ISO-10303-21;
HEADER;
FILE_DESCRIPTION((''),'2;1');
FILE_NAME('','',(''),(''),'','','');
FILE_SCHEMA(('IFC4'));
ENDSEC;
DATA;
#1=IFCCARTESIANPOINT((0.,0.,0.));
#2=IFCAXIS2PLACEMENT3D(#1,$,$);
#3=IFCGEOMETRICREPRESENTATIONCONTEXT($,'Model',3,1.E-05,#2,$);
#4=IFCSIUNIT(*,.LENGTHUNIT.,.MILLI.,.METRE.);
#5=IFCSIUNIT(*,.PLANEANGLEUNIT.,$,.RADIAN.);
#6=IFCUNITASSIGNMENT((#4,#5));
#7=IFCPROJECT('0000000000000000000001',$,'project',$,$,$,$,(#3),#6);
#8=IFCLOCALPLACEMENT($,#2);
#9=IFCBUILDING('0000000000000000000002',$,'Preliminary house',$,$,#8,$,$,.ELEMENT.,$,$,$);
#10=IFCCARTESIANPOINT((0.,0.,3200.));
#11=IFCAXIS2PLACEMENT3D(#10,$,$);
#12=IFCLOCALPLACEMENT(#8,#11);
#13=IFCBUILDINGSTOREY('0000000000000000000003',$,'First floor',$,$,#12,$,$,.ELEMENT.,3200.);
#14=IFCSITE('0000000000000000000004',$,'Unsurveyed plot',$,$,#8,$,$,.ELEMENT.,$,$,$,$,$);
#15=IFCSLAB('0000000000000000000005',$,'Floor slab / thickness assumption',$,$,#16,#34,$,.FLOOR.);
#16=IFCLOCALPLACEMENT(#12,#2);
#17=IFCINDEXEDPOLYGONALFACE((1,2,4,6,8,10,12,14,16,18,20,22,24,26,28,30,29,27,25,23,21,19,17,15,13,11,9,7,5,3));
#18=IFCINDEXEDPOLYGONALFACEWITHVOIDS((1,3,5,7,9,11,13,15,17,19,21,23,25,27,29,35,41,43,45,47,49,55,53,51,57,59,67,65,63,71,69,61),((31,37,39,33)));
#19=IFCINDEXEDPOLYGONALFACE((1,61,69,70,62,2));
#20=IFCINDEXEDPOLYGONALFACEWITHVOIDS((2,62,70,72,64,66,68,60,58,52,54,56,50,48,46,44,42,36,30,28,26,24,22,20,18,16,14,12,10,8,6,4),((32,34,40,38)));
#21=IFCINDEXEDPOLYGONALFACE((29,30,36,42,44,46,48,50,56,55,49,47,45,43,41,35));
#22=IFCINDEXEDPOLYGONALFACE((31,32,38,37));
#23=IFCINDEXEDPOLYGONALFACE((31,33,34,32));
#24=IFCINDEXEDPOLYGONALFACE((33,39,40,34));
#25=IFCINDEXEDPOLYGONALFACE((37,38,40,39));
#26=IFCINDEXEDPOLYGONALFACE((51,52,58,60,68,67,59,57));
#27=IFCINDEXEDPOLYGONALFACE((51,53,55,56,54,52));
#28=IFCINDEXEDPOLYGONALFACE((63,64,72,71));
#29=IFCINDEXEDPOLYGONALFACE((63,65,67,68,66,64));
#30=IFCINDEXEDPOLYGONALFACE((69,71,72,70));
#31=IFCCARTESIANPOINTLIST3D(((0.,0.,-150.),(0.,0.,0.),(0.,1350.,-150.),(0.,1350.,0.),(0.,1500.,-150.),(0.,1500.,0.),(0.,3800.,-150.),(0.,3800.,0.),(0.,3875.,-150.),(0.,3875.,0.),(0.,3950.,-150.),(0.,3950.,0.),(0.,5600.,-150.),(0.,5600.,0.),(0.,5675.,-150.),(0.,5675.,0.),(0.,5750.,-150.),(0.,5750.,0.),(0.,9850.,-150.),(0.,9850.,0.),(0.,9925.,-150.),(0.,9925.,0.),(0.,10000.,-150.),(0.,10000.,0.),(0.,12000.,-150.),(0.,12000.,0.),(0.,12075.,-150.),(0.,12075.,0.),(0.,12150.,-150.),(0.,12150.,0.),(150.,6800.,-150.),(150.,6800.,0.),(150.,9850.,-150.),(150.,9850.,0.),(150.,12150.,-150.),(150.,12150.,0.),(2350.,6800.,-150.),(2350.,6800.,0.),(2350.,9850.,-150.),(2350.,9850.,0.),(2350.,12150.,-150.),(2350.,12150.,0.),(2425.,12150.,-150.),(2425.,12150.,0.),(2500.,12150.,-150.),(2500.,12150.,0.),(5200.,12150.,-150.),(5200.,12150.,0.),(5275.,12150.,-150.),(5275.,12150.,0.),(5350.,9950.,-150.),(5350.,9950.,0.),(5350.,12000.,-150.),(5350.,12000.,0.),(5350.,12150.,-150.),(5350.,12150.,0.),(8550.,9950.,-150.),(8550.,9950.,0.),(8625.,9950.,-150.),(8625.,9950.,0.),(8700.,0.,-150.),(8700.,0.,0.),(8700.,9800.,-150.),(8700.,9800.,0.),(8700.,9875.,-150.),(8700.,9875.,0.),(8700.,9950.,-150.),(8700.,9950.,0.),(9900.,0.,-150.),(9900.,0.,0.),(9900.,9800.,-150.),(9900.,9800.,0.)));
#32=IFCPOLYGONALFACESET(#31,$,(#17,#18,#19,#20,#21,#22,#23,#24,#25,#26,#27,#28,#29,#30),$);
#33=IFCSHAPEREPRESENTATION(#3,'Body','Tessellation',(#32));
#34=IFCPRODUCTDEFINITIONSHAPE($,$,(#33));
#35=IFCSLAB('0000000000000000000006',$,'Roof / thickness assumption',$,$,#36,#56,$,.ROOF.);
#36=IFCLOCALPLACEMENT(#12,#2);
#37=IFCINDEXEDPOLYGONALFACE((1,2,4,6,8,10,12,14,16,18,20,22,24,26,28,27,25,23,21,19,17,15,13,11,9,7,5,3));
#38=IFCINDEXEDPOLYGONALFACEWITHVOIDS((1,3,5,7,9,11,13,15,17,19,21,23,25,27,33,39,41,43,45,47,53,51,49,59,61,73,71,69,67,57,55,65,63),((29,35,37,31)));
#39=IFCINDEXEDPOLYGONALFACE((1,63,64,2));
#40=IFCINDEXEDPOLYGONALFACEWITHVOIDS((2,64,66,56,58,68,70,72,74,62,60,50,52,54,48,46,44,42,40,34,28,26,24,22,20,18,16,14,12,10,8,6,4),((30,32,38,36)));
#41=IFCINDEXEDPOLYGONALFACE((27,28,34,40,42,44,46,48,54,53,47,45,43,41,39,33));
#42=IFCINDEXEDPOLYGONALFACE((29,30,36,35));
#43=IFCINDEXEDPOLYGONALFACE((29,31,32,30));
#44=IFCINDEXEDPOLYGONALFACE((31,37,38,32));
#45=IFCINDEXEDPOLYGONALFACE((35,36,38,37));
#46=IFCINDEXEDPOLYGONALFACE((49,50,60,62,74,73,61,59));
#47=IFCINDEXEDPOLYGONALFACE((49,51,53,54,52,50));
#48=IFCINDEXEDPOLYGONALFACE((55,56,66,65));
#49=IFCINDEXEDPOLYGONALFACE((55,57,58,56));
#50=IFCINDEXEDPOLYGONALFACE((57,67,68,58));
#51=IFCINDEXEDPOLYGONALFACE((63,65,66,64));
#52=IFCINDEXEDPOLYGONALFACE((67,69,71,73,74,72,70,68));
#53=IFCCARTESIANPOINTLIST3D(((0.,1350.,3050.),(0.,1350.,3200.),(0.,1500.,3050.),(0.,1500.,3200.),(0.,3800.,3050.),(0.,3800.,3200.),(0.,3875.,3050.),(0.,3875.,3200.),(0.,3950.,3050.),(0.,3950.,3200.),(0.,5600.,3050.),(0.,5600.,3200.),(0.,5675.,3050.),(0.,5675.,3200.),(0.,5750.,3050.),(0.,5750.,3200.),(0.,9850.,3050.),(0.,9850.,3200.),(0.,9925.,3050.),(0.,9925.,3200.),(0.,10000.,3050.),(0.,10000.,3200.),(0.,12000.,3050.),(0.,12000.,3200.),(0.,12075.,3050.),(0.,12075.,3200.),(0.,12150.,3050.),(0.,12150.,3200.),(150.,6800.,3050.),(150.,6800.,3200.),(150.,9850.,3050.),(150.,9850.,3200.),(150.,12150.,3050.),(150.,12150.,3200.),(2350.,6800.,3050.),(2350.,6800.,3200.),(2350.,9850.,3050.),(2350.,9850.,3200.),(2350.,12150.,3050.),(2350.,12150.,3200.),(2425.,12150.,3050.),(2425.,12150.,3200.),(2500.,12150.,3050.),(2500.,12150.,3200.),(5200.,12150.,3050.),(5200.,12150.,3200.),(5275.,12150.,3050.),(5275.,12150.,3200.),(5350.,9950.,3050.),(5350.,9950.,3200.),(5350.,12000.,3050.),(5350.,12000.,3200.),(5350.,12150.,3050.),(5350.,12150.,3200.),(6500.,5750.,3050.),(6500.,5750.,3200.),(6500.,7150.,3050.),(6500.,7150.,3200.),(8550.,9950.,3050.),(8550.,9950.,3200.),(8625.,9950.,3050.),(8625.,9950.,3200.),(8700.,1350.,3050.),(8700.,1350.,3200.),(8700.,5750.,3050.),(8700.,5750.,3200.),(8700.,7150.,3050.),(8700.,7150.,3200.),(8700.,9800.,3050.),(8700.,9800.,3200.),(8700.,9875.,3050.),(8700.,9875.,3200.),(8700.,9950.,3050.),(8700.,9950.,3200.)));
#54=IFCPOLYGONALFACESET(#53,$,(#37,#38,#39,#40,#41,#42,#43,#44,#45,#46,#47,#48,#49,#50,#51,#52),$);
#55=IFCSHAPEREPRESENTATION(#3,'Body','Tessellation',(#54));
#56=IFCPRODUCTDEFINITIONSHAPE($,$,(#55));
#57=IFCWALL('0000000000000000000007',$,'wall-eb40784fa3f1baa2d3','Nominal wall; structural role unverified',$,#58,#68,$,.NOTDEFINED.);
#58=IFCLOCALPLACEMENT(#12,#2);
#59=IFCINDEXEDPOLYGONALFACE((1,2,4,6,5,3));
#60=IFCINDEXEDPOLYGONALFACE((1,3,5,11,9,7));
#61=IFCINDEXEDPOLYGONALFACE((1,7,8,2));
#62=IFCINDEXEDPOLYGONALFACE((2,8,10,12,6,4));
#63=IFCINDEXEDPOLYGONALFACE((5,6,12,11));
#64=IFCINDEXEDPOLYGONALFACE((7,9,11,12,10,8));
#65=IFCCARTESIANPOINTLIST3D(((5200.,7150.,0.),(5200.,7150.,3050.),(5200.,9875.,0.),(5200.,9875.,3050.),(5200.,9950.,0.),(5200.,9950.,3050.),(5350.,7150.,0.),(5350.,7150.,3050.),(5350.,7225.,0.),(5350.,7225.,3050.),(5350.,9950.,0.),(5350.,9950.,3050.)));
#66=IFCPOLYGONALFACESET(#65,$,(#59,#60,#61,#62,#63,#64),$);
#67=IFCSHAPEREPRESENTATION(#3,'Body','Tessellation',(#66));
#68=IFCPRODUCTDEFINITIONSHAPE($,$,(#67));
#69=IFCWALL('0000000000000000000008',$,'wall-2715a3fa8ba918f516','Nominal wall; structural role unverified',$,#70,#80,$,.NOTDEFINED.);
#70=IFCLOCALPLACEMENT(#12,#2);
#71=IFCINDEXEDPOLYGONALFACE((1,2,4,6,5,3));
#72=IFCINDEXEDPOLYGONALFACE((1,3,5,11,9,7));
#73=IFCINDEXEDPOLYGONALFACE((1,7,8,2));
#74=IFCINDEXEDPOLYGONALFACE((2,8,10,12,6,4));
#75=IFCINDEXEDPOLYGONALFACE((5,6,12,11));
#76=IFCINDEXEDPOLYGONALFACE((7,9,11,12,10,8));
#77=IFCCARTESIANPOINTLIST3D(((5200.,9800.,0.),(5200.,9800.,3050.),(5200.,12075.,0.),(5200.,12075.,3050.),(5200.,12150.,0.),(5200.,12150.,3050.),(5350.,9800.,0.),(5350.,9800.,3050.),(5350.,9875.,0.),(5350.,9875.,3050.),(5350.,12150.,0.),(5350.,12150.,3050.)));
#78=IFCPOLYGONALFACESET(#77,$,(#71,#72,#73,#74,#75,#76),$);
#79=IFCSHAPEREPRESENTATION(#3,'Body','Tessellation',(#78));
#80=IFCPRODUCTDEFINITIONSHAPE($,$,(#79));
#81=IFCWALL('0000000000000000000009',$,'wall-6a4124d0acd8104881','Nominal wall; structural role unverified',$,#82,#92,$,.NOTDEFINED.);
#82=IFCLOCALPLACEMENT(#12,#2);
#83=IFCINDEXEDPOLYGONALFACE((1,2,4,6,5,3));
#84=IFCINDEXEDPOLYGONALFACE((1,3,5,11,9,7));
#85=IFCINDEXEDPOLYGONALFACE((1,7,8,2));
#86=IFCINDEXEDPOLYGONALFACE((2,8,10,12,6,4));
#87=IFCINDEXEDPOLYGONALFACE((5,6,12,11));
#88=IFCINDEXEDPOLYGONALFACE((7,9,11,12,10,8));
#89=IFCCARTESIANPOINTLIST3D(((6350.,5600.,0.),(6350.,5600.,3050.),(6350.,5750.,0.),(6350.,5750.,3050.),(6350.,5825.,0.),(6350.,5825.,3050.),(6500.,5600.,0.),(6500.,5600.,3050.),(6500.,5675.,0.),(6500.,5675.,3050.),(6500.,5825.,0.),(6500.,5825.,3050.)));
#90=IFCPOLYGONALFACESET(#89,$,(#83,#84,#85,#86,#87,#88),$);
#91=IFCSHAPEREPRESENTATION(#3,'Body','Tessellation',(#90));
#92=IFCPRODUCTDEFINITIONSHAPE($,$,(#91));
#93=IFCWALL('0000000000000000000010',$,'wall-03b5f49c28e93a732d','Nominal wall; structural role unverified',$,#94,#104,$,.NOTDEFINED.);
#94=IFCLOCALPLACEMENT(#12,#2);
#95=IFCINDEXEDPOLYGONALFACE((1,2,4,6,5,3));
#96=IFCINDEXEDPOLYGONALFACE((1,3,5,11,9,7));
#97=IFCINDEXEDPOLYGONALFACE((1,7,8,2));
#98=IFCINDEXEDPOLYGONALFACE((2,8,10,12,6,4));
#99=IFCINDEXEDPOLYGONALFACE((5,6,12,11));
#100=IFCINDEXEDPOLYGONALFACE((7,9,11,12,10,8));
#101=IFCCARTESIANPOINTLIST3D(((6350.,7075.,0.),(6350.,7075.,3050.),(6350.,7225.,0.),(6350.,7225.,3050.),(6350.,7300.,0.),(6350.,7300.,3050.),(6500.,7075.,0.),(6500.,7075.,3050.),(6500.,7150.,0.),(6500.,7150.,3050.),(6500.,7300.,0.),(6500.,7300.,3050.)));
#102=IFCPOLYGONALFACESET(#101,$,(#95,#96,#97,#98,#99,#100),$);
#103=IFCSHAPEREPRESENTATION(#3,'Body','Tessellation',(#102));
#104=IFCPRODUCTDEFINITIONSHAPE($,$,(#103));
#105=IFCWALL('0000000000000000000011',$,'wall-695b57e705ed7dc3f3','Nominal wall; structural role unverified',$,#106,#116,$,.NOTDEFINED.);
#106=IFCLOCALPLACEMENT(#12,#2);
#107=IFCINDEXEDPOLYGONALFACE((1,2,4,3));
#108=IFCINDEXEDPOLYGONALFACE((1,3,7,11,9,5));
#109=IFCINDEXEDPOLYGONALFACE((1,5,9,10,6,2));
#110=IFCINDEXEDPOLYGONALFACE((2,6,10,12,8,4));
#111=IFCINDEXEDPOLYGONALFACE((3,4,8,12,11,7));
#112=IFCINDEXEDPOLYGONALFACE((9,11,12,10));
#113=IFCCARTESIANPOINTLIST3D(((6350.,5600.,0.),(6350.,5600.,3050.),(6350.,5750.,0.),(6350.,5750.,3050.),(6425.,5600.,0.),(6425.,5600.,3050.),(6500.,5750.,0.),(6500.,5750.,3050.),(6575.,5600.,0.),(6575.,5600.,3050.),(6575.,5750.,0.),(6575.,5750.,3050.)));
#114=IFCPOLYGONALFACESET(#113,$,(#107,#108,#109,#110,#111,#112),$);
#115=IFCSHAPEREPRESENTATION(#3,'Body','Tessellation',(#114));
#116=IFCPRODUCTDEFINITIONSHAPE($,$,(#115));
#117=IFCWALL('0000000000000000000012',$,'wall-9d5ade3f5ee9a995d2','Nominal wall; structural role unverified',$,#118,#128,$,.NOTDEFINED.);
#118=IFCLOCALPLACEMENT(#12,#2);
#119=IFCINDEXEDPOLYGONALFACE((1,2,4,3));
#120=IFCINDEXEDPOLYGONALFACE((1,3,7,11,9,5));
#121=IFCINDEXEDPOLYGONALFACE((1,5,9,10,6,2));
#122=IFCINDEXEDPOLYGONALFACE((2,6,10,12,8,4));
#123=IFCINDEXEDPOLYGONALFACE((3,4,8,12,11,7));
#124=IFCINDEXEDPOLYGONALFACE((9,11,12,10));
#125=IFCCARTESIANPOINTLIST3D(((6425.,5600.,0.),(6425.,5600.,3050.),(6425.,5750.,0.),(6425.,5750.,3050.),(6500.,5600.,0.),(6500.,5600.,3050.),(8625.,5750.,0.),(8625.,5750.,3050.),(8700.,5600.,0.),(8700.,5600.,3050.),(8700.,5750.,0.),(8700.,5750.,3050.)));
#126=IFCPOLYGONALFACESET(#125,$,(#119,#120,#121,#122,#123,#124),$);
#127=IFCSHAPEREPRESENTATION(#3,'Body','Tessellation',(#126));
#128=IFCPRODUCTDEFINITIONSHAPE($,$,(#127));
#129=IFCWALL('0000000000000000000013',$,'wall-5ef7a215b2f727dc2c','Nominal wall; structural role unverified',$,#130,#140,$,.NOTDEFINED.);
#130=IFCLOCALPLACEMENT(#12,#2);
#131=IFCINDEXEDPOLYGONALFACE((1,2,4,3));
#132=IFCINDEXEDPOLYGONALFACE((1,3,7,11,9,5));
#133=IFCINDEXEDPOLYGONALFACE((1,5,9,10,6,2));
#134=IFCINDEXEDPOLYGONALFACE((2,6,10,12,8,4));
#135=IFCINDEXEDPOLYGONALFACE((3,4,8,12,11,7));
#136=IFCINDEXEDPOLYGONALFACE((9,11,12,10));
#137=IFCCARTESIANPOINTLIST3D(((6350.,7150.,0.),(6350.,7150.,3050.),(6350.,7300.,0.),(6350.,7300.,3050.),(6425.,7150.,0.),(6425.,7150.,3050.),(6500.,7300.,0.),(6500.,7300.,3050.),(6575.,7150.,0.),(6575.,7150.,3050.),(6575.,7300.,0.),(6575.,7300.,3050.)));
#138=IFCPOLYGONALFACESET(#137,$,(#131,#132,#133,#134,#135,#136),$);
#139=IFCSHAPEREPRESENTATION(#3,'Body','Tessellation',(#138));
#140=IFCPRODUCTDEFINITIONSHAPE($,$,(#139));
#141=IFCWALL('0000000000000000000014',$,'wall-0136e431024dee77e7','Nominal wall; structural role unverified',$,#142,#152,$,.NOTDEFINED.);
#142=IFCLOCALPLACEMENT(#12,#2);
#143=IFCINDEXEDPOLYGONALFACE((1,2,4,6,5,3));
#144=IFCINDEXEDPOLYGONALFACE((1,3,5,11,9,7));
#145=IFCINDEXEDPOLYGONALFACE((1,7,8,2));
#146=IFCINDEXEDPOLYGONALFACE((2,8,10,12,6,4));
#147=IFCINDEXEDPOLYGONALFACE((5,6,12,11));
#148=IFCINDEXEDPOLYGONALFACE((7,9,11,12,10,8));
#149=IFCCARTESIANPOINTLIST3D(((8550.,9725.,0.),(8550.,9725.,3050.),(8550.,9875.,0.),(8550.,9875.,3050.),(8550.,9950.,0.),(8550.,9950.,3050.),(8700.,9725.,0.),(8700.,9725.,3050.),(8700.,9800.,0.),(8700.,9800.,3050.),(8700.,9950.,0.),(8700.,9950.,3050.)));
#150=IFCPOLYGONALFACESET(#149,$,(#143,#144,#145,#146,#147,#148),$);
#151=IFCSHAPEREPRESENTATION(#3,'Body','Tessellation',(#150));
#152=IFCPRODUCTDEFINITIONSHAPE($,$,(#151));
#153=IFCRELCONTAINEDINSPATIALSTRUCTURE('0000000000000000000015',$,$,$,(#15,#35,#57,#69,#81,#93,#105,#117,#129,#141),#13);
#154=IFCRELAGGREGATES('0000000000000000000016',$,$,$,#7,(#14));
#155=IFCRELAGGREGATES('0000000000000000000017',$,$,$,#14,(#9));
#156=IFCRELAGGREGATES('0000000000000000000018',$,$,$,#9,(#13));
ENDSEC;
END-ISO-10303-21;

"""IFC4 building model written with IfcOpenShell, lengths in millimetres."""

from ifc_helpers import new_model, si_unit, frame, origin, place, context, project, spatial, polyline, outline, extrude, element, save


model = new_model("IFC4")

# Units and contexts
model_context = context("Model", 3, precision=1e-05, world=origin())
ifc_project = project(units=[si_unit("LENGTHUNIT", "METRE", prefix="MILLI"), si_unit("PLANEANGLEUNIT", "RADIAN")], contexts=[model_context])

# Site, building, storey
placement_1 = place(None, origin())
site = spatial("IfcSite", under=ifc_project, at=placement_1, Name="Unsurveyed plot", CompositionType="ELEMENT")
building = spatial("IfcBuilding", under=site, at=placement_1, Name="Preliminary house", CompositionType="ELEMENT")
placement_2 = place(placement_1, frame((0.0, 0.0, 3200.0)))
storey = spatial("IfcBuildingStorey", under=building, at=placement_2, Name="First floor", CompositionType="ELEMENT", Elevation=3200.0)

# Slabs
element("IfcSlab", 1, at=placement_2, inside=storey, Name="Floor slab / thickness assumption", PredefinedType="FLOOR", context=model_context, shape_type="SweptSolid", body=[
    extrude(outline(polyline([(0.0, 3875.0), (0.0, 3950.0), (0.0, 5600.0), (0.0, 5675.0), (0.0, 5750.0), (0.0, 9850.0), (0.0, 9925.0), (0.0, 10000.0), (0.0, 12000.0), (0.0, 12075.0), (0.0, 12150.0), (150.0, 12150.0), (2350.0, 12150.0), (2425.0, 12150.0), (2500.0, 12150.0), (5200.0, 12150.0), (5275.0, 12150.0), (5350.0, 12150.0), (5350.0, 12000.0), (5350.0, 9950.0), (8550.0, 9950.0), (8625.0, 9950.0), (8700.0, 9950.0), (8700.0, 9875.0), (8700.0, 9800.0), (9900.0, 9800.0), (9900.0, 0.0), (8700.0, 0.0), (0.0, 0.0), (0.0, 1350.0), (0.0, 1500.0), (0.0, 3800.0), (0.0, 3875.0)]), holes=[polyline([(2350.0, 9850.0), (150.0, 9850.0), (150.0, 6800.0), (2350.0, 6800.0), (2350.0, 9850.0)])]), frame((0.0, 0.0, -150.0)), (0.0, 0.0, 1.0), 150.0),
])
element("IfcSlab", 2, at=placement_2, inside=storey, Name="Roof / thickness assumption", PredefinedType="ROOF", context=model_context, shape_type="SweptSolid", body=[
    extrude(outline(polyline([(0.0, 5600.0), (0.0, 5675.0), (0.0, 5750.0), (0.0, 9850.0), (0.0, 9925.0), (0.0, 10000.0), (0.0, 12000.0), (0.0, 12075.0), (0.0, 12150.0), (150.0, 12150.0), (2350.0, 12150.0), (2425.0, 12150.0), (2500.0, 12150.0), (5200.0, 12150.0), (5275.0, 12150.0), (5350.0, 12150.0), (5350.0, 12000.0), (5350.0, 9950.0), (8550.0, 9950.0), (8625.0, 9950.0), (8700.0, 9950.0), (8700.0, 9875.0), (8700.0, 9800.0), (8700.0, 7150.0), (6500.0, 7150.0), (6500.0, 5750.0), (8700.0, 5750.0), (8700.0, 1350.0), (0.0, 1350.0), (0.0, 1500.0), (0.0, 3800.0), (0.0, 3875.0), (0.0, 3950.0), (0.0, 5600.0)]), holes=[polyline([(2350.0, 9850.0), (150.0, 9850.0), (150.0, 6800.0), (2350.0, 6800.0), (2350.0, 9850.0)])]), frame((0.0, 0.0, 3050.0)), (0.0, 0.0, 1.0), 150.0),
])

# Wall
element("IfcWall", 3, at=placement_2, inside=storey, Name="wall-eb40784fa3f1baa2d3", Description="Nominal wall; structural role unverified", PredefinedType="NOTDEFINED", context=model_context, shape_type="SweptSolid", body=[
    extrude(outline(polyline([(5200.0, 9875.0), (5200.0, 9950.0), (5350.0, 9950.0), (5350.0, 7225.0), (5350.0, 7150.0), (5200.0, 7150.0), (5200.0, 9875.0)])), origin(), (0.0, 0.0, 1.0), 3050.0),
])

# Wall
element("IfcWall", 4, at=placement_2, inside=storey, Name="wall-2715a3fa8ba918f516", Description="Nominal wall; structural role unverified", PredefinedType="NOTDEFINED", context=model_context, shape_type="SweptSolid", body=[
    extrude(outline(polyline([(5200.0, 12075.0), (5200.0, 12150.0), (5350.0, 12150.0), (5350.0, 9875.0), (5350.0, 9800.0), (5200.0, 9800.0), (5200.0, 12075.0)])), origin(), (0.0, 0.0, 1.0), 3050.0),
])

# Wall
element("IfcWall", 5, at=placement_2, inside=storey, Name="wall-6a4124d0acd8104881", Description="Nominal wall; structural role unverified", PredefinedType="NOTDEFINED", context=model_context, shape_type="SweptSolid", body=[
    extrude(outline(polyline([(6350.0, 5750.0), (6350.0, 5825.0), (6500.0, 5825.0), (6500.0, 5675.0), (6500.0, 5600.0), (6350.0, 5600.0), (6350.0, 5750.0)])), origin(), (0.0, 0.0, 1.0), 3050.0),
])

# Walls
element("IfcWall", 6, at=placement_2, inside=storey, Name="wall-03b5f49c28e93a732d", Description="Nominal wall; structural role unverified", PredefinedType="NOTDEFINED", context=model_context, shape_type="SweptSolid", body=[
    extrude(outline(polyline([(6350.0, 7225.0), (6350.0, 7300.0), (6500.0, 7300.0), (6500.0, 7150.0), (6500.0, 7075.0), (6350.0, 7075.0), (6350.0, 7225.0)])), origin(), (0.0, 0.0, 1.0), 3050.0),
])
element("IfcWall", 7, at=placement_2, inside=storey, Name="wall-695b57e705ed7dc3f3", Description="Nominal wall; structural role unverified", PredefinedType="NOTDEFINED", context=model_context, shape_type="SweptSolid", body=[
    extrude(outline(polyline([(6500.0, 5750.0), (6575.0, 5750.0), (6575.0, 5600.0), (6425.0, 5600.0), (6350.0, 5600.0), (6350.0, 5750.0), (6500.0, 5750.0)])), origin(), (0.0, 0.0, 1.0), 3050.0),
])
element("IfcWall", 8, at=placement_2, inside=storey, Name="wall-9d5ade3f5ee9a995d2", Description="Nominal wall; structural role unverified", PredefinedType="NOTDEFINED", context=model_context, shape_type="SweptSolid", body=[
    extrude(outline(polyline([(8625.0, 5750.0), (8700.0, 5750.0), (8700.0, 5600.0), (6500.0, 5600.0), (6425.0, 5600.0), (6425.0, 5750.0), (8625.0, 5750.0)])), origin(), (0.0, 0.0, 1.0), 3050.0),
])
element("IfcWall", 9, at=placement_2, inside=storey, Name="wall-5ef7a215b2f727dc2c", Description="Nominal wall; structural role unverified", PredefinedType="NOTDEFINED", context=model_context, shape_type="SweptSolid", body=[
    extrude(outline(polyline([(6500.0, 7300.0), (6575.0, 7300.0), (6575.0, 7150.0), (6425.0, 7150.0), (6350.0, 7150.0), (6350.0, 7300.0), (6500.0, 7300.0)])), origin(), (0.0, 0.0, 1.0), 3050.0),
])

# Wall
element("IfcWall", 10, at=placement_2, inside=storey, Name="wall-0136e431024dee77e7", Description="Nominal wall; structural role unverified", PredefinedType="NOTDEFINED", context=model_context, shape_type="SweptSolid", body=[
    extrude(outline(polyline([(8550.0, 9875.0), (8550.0, 9950.0), (8700.0, 9950.0), (8700.0, 9800.0), (8700.0, 9725.0), (8550.0, 9725.0), (8550.0, 9875.0)])), origin(), (0.0, 0.0, 1.0), 3050.0),
])

save(model, "model.ifc")
